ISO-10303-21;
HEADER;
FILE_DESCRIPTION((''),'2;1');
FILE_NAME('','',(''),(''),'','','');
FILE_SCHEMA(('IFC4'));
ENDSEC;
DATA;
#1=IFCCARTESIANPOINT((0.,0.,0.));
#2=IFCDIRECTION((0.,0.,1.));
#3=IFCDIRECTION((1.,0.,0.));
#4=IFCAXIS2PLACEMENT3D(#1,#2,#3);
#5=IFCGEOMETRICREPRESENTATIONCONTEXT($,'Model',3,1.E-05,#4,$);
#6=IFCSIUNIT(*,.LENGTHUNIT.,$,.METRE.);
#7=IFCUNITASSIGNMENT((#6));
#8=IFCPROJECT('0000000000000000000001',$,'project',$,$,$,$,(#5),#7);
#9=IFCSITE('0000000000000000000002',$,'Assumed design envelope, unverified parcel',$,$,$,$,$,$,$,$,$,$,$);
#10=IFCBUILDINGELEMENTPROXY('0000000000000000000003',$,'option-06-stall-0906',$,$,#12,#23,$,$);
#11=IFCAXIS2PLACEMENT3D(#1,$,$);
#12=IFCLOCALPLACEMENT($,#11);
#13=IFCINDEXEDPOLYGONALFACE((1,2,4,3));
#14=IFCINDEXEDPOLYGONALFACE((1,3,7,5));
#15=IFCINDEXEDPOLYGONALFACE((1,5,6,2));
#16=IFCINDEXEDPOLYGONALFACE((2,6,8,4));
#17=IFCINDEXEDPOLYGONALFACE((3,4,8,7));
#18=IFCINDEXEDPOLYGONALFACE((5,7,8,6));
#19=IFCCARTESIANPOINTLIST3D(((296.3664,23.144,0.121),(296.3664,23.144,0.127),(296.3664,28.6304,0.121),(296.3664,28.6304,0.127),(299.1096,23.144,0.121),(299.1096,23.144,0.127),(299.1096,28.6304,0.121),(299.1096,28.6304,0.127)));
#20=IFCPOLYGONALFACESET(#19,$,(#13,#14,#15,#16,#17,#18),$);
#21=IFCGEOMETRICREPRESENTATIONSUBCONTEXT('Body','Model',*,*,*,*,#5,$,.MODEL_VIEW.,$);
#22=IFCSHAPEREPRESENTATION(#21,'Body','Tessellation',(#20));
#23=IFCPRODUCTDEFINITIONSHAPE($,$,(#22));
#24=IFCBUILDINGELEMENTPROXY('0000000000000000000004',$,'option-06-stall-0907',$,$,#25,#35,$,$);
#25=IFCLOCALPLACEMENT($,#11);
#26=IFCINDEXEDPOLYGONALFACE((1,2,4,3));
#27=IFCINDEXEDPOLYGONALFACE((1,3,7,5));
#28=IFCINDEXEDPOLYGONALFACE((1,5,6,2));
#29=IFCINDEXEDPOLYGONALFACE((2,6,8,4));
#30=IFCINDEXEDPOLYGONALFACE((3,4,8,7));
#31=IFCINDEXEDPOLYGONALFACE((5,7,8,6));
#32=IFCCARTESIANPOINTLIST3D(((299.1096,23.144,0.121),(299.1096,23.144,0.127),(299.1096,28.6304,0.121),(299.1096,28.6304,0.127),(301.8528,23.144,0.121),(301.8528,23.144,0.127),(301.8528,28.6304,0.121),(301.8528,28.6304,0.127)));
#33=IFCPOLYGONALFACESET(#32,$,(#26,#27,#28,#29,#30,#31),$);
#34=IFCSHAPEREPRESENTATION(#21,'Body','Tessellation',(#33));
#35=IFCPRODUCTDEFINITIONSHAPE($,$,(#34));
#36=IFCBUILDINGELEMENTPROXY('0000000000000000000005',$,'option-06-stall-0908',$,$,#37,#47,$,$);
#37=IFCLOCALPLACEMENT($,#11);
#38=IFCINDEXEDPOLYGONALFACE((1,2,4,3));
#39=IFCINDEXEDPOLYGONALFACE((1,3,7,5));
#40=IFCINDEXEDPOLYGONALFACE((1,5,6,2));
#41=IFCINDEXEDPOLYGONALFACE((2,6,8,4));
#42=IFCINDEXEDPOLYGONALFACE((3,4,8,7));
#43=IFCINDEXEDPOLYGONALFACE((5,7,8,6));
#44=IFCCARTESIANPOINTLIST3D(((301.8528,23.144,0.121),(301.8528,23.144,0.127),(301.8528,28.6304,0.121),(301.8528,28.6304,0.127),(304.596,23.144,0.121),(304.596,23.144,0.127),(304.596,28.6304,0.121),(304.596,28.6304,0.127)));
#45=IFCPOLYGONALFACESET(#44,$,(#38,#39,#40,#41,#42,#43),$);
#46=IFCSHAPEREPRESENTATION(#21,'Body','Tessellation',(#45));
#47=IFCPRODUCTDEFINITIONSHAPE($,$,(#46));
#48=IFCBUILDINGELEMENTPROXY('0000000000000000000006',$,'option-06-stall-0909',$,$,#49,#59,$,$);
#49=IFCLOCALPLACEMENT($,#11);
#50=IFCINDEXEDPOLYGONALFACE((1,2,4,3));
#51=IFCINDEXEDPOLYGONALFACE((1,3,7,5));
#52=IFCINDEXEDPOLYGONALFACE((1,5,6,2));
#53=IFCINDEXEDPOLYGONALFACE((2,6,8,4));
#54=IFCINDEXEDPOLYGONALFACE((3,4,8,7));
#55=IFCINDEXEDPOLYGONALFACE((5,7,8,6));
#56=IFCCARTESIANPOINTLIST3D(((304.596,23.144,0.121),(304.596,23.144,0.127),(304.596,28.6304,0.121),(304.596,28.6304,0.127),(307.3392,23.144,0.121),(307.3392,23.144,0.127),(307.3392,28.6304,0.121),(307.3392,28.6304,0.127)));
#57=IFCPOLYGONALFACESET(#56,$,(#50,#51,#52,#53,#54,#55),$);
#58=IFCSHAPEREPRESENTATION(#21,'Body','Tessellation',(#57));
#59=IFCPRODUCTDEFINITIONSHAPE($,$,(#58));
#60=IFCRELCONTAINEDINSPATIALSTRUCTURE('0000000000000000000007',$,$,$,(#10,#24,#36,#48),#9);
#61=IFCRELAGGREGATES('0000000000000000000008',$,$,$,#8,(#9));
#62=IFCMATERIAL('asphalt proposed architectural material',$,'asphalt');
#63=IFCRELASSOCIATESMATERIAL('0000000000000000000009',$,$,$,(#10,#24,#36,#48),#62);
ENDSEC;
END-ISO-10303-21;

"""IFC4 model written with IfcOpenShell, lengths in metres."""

from ifc_helpers import new_model, si_unit, frame, origin_with_axes, place, context, subcontext, project, spatial, rectangle, extrude, material, element, save


model = new_model("IFC4")

# Units and contexts
model_context = context("Model", 3, precision=1e-05, world=origin_with_axes())
body_context = subcontext(model_context, "Body", "Model", "MODEL_VIEW")
ifc_project = project(units=[si_unit("LENGTHUNIT", "METRE")], contexts=[model_context])

# Site
site = spatial("IfcSite", under=ifc_project, Name="Assumed design envelope, unverified parcel")

# Building element proxies
ifc_material = material(Name="asphalt proposed architectural material", Category="asphalt")
for number, where, z_axis, x_axis, name in (
    (1, (297.738, 25.8872, 0.121), (0.0, 0.0, 1.0), (1.0, 0.0, 0.0), "option-06-stall-0906"),
    (2, (300.4812, 25.8872, 0.121), (0.0, 0.0, 1.0), (1.0, 0.0, 0.0), "option-06-stall-0907"),
    (3, (303.2244, 25.8872, 0.121), (0.0, 0.0, 1.0), (1.0, 0.0, 0.0), "option-06-stall-0908"),
    (4, (305.9676, 25.8872, 0.121), (0.0, 0.0, 1.0), (1.0, 0.0, 0.0), "option-06-stall-0909"),
):
    element("IfcBuildingElementProxy", number, at=place(None, frame(where, z_axis=z_axis, x_axis=x_axis)), inside=site, material=ifc_material, Name=name, context=body_context, shape_type="SweptSolid", body=[
        extrude(rectangle(XDim=2.7432, YDim=5.4864), origin_with_axes(), (0.0, 0.0, 1.0), 0.006),
    ])

save(model, "model.ifc")
